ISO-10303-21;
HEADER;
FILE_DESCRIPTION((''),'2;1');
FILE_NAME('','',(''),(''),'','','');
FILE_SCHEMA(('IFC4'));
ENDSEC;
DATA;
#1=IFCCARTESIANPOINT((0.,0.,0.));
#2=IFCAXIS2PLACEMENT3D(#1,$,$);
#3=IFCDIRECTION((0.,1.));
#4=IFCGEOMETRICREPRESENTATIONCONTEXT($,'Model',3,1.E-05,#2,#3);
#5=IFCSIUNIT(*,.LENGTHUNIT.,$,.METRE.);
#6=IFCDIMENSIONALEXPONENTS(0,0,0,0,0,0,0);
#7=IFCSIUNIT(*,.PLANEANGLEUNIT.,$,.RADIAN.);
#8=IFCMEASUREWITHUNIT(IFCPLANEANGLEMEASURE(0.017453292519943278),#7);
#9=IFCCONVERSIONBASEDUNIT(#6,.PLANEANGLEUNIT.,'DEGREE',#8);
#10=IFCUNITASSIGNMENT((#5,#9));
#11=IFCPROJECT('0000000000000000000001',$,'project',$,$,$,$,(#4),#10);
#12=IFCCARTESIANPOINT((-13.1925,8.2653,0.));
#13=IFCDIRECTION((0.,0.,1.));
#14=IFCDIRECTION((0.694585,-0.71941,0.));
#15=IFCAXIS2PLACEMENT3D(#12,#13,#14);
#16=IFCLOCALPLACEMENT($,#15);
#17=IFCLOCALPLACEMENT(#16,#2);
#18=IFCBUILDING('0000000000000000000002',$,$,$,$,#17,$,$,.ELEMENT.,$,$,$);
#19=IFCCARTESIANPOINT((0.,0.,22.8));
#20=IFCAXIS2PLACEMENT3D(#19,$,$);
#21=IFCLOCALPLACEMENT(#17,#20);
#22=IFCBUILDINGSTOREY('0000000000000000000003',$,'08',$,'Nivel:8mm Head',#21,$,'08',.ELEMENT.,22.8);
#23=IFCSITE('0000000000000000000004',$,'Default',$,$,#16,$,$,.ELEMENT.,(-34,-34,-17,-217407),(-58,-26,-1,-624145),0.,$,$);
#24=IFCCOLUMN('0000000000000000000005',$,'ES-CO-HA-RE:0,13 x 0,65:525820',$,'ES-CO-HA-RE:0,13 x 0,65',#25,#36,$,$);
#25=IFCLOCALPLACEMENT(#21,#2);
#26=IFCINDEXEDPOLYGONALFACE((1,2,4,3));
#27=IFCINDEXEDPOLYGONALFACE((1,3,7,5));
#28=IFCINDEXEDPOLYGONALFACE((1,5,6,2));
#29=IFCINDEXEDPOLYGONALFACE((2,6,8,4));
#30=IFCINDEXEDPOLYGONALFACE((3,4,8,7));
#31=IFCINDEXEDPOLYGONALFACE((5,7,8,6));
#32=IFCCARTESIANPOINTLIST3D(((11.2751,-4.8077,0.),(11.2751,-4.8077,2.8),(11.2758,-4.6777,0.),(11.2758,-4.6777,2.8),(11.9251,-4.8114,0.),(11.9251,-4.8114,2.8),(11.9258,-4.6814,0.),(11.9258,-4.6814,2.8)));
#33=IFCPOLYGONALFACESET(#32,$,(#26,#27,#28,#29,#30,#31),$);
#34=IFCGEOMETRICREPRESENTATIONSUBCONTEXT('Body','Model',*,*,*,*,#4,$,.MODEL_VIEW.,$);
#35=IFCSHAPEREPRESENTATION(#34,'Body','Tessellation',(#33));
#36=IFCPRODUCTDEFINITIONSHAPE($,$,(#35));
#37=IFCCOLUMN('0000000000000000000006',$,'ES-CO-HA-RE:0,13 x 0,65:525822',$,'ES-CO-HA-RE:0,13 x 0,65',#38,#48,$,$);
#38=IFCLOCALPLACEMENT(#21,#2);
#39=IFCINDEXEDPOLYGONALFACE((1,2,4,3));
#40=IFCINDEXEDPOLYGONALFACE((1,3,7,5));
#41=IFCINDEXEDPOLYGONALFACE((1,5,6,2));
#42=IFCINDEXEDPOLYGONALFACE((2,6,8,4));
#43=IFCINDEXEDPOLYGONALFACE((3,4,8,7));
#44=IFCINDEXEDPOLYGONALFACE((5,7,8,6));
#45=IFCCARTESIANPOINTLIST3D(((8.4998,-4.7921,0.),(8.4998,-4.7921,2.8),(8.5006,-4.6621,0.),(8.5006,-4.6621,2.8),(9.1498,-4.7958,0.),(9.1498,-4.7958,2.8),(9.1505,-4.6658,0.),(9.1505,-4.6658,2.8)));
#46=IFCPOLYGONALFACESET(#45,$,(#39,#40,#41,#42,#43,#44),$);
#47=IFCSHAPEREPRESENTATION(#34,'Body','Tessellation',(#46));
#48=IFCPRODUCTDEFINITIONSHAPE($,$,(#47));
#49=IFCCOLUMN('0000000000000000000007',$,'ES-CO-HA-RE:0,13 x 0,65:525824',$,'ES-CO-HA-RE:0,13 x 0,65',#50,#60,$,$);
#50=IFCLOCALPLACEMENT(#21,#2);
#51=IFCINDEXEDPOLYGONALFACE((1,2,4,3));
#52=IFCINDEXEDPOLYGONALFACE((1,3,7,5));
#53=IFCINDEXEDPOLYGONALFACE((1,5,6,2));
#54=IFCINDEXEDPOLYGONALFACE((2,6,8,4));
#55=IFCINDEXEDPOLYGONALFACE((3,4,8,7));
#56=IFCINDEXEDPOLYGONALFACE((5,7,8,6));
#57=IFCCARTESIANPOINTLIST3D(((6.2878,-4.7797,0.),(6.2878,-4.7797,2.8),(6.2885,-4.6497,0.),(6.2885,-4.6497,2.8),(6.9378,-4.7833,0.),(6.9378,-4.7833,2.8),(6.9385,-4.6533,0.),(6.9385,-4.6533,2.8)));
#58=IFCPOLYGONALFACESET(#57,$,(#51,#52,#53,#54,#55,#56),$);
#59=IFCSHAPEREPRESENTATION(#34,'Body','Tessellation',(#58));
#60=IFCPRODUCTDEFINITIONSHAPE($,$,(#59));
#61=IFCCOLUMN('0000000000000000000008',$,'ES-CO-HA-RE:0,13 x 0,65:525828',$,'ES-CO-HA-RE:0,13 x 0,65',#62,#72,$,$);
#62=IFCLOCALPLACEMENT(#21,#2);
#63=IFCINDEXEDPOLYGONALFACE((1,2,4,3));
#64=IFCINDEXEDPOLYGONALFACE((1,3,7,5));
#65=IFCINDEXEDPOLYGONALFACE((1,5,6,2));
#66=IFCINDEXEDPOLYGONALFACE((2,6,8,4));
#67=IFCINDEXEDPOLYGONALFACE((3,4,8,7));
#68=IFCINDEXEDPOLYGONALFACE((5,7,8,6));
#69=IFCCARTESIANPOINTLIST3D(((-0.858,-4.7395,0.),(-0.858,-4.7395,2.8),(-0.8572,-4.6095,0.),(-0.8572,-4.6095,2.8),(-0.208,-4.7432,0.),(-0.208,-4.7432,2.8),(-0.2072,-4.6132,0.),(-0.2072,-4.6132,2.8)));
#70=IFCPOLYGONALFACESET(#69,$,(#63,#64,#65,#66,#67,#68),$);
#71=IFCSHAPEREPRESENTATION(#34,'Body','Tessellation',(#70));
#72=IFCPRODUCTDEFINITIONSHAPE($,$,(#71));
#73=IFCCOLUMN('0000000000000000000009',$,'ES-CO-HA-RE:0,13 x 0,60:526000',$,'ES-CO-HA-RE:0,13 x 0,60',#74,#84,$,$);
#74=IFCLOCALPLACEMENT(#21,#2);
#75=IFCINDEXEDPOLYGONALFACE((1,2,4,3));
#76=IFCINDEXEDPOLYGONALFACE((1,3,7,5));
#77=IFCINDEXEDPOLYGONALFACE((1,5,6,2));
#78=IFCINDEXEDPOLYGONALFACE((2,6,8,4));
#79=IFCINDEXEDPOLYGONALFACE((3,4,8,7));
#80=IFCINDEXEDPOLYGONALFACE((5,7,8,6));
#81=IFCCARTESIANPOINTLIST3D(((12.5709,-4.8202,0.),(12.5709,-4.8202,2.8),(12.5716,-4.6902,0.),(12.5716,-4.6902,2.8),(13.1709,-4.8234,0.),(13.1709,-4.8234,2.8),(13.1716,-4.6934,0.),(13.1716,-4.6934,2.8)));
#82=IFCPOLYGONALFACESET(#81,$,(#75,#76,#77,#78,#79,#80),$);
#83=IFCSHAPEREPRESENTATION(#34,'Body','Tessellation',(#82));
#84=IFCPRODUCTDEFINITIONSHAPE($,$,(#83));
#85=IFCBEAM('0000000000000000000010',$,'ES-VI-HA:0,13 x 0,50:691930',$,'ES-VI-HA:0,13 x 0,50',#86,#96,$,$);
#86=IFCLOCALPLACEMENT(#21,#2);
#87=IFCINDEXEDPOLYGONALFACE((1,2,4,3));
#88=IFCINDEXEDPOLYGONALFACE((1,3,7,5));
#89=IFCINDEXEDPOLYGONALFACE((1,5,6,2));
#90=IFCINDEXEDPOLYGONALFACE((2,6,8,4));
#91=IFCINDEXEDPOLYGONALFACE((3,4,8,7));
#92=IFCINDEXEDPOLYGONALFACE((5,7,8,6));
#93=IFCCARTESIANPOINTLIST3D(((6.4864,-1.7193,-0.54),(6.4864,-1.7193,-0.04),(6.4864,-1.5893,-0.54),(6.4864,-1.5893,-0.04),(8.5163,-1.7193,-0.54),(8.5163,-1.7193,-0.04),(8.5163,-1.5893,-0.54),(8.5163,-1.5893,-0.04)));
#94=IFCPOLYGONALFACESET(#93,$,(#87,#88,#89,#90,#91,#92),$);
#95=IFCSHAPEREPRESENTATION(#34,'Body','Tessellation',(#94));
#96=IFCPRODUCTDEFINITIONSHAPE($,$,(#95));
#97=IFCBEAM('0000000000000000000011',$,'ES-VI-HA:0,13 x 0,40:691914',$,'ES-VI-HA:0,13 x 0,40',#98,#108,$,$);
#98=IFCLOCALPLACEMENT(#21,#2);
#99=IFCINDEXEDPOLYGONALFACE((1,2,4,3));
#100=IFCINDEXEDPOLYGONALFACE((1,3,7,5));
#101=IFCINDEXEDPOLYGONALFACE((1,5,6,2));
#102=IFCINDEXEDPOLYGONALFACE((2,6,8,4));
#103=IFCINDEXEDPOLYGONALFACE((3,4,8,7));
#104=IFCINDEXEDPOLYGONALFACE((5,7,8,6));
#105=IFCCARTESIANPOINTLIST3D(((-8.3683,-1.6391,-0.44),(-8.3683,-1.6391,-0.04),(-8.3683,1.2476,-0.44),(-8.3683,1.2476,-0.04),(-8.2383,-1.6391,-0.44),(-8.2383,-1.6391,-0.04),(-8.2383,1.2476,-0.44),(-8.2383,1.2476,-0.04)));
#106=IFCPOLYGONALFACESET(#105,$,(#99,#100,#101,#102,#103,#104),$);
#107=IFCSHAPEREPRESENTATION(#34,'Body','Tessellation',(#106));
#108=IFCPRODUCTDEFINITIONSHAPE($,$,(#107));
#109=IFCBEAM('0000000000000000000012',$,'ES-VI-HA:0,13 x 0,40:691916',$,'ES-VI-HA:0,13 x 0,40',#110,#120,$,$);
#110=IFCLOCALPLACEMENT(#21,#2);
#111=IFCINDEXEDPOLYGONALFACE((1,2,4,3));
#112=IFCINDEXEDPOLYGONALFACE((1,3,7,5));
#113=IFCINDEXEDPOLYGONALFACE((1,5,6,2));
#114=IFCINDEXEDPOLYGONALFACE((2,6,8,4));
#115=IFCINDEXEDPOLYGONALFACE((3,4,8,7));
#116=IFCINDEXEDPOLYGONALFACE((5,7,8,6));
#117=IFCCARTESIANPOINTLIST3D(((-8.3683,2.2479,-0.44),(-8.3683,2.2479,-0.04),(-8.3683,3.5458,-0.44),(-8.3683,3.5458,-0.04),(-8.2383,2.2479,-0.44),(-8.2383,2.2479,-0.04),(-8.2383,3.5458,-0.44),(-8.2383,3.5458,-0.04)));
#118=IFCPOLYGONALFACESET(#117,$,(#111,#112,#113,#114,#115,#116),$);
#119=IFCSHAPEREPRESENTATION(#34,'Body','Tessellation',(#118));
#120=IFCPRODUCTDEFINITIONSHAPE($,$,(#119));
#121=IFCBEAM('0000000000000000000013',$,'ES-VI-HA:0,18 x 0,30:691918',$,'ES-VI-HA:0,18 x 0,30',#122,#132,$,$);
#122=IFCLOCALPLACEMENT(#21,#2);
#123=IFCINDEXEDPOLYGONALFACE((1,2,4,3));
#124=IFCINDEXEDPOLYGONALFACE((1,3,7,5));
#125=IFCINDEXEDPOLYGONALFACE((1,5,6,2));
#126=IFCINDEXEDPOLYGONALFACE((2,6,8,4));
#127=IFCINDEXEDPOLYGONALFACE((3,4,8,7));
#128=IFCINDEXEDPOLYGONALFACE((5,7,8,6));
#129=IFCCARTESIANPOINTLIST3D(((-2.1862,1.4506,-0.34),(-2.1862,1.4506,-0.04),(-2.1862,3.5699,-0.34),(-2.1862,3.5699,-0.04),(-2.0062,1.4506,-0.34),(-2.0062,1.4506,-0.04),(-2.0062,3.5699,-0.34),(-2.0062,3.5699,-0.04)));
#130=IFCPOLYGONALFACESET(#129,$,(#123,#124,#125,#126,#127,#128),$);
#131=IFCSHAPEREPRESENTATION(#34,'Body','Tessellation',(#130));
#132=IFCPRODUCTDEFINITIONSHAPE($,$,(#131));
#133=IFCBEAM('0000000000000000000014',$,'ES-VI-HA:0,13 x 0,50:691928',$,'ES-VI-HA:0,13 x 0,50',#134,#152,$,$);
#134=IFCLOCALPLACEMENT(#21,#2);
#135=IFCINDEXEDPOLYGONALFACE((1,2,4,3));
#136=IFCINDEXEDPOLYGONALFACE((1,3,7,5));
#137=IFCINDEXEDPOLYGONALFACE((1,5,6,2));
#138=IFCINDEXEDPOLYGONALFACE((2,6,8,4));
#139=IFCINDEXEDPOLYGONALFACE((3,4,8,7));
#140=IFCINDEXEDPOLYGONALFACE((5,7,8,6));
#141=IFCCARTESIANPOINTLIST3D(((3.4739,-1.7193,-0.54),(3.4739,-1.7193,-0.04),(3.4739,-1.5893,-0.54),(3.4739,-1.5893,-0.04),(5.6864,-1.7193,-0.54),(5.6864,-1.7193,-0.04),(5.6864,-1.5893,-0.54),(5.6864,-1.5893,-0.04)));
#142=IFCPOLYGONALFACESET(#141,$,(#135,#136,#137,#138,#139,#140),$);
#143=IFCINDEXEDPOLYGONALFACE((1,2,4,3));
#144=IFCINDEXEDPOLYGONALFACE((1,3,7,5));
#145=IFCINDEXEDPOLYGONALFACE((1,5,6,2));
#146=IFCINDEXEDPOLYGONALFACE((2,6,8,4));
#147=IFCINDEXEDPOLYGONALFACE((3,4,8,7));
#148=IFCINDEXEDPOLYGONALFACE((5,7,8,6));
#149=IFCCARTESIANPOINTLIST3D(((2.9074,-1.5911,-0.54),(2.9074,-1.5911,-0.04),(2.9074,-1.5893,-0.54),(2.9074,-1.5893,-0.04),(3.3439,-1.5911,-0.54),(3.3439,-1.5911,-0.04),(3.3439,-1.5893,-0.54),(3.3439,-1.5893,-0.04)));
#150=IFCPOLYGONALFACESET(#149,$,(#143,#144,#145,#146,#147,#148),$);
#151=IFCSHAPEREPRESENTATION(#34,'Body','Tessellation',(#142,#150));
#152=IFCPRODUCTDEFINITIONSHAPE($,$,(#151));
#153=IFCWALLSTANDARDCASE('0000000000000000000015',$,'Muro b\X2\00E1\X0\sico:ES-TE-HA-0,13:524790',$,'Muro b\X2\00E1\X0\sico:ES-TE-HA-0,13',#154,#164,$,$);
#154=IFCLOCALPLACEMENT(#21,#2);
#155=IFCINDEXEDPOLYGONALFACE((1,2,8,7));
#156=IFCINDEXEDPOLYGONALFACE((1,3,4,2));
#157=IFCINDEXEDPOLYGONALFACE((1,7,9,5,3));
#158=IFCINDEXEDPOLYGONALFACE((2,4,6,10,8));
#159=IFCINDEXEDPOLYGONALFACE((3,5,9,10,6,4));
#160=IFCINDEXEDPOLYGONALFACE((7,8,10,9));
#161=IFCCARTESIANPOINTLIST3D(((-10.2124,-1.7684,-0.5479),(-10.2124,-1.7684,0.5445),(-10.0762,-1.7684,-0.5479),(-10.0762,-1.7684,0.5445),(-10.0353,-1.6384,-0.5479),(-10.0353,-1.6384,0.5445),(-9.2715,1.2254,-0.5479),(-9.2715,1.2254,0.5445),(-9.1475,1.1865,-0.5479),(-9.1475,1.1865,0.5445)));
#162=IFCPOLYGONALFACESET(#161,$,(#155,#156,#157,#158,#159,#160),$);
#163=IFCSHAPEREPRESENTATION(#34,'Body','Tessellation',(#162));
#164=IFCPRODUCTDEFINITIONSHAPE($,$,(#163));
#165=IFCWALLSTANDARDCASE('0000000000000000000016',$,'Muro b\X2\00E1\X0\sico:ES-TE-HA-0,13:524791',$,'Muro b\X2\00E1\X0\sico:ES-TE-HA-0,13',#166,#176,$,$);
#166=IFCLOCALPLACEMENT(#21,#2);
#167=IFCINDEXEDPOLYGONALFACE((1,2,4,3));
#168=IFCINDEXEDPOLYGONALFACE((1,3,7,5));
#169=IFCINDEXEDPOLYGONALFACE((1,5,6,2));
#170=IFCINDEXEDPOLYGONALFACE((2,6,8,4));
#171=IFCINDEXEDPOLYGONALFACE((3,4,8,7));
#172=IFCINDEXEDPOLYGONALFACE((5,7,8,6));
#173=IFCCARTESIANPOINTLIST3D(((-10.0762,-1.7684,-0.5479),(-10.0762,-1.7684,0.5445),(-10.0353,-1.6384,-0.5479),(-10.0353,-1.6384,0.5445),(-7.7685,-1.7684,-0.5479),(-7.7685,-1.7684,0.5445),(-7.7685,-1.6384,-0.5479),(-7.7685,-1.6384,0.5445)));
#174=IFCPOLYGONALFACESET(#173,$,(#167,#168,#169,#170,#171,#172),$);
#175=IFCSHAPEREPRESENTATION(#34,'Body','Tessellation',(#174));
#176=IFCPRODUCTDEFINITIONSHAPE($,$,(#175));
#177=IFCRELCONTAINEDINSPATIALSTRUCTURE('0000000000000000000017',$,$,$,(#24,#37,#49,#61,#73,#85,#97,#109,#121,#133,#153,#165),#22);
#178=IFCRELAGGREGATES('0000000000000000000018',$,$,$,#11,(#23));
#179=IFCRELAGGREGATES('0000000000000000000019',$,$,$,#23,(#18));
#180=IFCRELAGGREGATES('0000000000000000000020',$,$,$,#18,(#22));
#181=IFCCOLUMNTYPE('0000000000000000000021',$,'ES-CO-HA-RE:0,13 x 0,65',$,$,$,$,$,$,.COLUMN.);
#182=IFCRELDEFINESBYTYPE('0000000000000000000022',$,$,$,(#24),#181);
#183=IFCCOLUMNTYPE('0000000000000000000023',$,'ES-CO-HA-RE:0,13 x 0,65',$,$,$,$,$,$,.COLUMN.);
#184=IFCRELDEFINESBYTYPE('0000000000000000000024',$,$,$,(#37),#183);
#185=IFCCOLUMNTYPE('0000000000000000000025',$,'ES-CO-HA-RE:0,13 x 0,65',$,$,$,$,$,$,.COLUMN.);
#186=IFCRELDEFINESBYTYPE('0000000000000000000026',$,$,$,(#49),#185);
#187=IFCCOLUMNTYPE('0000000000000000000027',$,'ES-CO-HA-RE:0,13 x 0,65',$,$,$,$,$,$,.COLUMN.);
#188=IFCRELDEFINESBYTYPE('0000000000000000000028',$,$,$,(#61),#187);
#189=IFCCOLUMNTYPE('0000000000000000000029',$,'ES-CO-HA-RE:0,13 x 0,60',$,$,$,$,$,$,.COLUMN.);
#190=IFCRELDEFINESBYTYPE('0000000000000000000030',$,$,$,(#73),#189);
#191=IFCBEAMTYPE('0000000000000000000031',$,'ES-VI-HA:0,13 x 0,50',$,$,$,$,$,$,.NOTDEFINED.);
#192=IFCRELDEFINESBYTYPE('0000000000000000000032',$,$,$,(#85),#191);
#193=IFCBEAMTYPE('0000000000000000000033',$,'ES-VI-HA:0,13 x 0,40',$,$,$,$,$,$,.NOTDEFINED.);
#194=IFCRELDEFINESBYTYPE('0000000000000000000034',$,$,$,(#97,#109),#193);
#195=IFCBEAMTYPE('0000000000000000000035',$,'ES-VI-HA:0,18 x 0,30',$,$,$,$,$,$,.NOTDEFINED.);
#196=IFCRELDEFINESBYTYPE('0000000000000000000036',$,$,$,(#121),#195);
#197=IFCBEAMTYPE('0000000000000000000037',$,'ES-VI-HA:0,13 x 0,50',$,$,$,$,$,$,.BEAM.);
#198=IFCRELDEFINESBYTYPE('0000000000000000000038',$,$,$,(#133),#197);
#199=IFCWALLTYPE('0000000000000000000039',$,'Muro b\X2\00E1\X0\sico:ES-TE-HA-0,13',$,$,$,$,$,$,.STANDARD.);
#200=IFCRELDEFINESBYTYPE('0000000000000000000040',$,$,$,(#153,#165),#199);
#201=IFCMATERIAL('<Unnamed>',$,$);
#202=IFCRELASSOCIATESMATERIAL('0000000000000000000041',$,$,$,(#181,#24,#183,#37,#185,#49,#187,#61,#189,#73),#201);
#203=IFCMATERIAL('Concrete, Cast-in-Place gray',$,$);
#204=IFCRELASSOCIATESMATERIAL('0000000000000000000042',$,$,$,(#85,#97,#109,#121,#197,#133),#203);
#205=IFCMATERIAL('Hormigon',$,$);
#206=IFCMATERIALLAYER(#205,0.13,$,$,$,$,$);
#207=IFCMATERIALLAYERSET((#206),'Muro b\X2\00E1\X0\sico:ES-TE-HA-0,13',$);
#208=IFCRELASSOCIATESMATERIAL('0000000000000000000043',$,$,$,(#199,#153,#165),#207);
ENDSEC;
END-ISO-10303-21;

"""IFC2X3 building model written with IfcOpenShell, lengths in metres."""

from ifc_helpers import new_model, entity, si_unit, converted_unit, direction, frame, frame_2d, origin, origin_2d_with_axis, place, context, subcontext, project, spatial, polyline, rectangle, outline, extrude, source, transform, mapped, material, layer, layer_set, layer_usage, type_object, type_shapes, element, save


model = new_model("IFC2X3")

# Units and contexts
model_context = context("Model", 3, precision=1e-05, world=origin(), true_north=direction((0.0, 1.0)))
body_context = subcontext(model_context, "Body", "Model", "MODEL_VIEW")
ifc_project = project(units=[si_unit("LENGTHUNIT", "METRE"), converted_unit("PLANEANGLEUNIT", "DEGREE", entity("IfcPlaneAngleMeasure", 0.017453292519943278), si_unit("PLANEANGLEUNIT", "RADIAN"), dimensions=[0, 0, 0, 0, 0, 0, 0])], contexts=[model_context])

# Site, building, storey
site_placement = place(None, frame((-13.1925, 8.2653, 0.0), z_axis=(0.0, 0.0, 1.0), x_axis=(0.694585, -0.71941, 0.0)))
site = spatial("IfcSite", under=ifc_project, at=site_placement, Name="Default", CompositionType="ELEMENT", RefLatitude=(-34, -34, -17, -217407), RefLongitude=(-58, -26, -1, -624145), RefElevation=0.0)
building_placement = place(site_placement, origin())
building = spatial("IfcBuilding", under=site, at=building_placement, CompositionType="ELEMENT")
storey_placement = place(building_placement, frame((0.0, 0.0, 22.8)))
storey = spatial("IfcBuildingStorey", under=building, at=storey_placement, Name="08", ObjectType="Nivel:8mm Head", LongName="08", CompositionType="ELEMENT", Elevation=22.8)

# Columns
ifc_material_1 = material(Name="<Unnamed>")
ifc_material_2 = material(Name="Hormigon")
column_type_1 = type_object("IfcColumnType", Name="ES-CO-HA-RE:0,13 x 0,65", PredefinedType="COLUMN", material=ifc_material_1)
shared_shape_1 = source(origin(), body_context, "Body", "SweptSolid", [
    extrude(rectangle(XDim=0.65, YDim=0.13, at=frame_2d((0.0, 0.0), x_axis=(1.0, 0.0))), frame((11.6005, -4.7445, 22.8), z_axis=(0.0, 0.0, 1.0), x_axis=(-0.999984, 0.005619, 0.0)), (0.0, 0.0, 1.0), 2.8),
])
type_shapes(column_type_1, [shared_shape_1])
column_1_placement = place(storey_placement, frame((0.0, 0.0, -22.8)))
element("IfcColumn", 1, at=column_1_placement, inside=storey, type_object=column_type_1, material=ifc_material_1, Name="ES-CO-HA-RE:0,13 x 0,65:525820", ObjectType="ES-CO-HA-RE:0,13 x 0,65", context=body_context, shape_type="MappedRepresentation", body=[
    mapped(shared_shape_1, transform((0.0, 0.0, 0.0), scale=1.0)),
])
column_type_2 = type_object("IfcColumnType", Name="ES-CO-HA-RE:0,13 x 0,65", PredefinedType="COLUMN", material=ifc_material_1)
shared_shape_2 = source(origin(), body_context, "Body", "SweptSolid", [
    extrude(rectangle(XDim=0.65, YDim=0.13, at=origin_2d_with_axis()), frame((8.8252, -4.7289, 22.8), z_axis=(0.0, 0.0, 1.0), x_axis=(-0.999984, 0.005619, 0.0)), (0.0, 0.0, 1.0), 2.8),
])
type_shapes(column_type_2, [shared_shape_2])
column_2_placement = place(storey_placement, frame((0.0, 0.0, -22.8)))
element("IfcColumn", 2, at=column_2_placement, inside=storey, type_object=column_type_2, material=ifc_material_1, Name="ES-CO-HA-RE:0,13 x 0,65:525822", ObjectType="ES-CO-HA-RE:0,13 x 0,65", context=body_context, shape_type="MappedRepresentation", body=[
    mapped(shared_shape_2, transform((0.0, 0.0, 0.0), scale=1.0)),
])
column_type_3 = type_object("IfcColumnType", Name="ES-CO-HA-RE:0,13 x 0,65", PredefinedType="COLUMN", material=ifc_material_1)
shared_shape_3 = source(origin(), body_context, "Body", "SweptSolid", [
    extrude(rectangle(XDim=0.65, YDim=0.13, at=frame_2d((0.0, 0.0), x_axis=(1.0, 0.0))), frame((6.6131, -4.7165, 22.8), z_axis=(0.0, 0.0, 1.0), x_axis=(-0.999984, 0.005619, 0.0)), (0.0, 0.0, 1.0), 2.8),
])
type_shapes(column_type_3, [shared_shape_3])
column_3_placement = place(storey_placement, frame((0.0, 0.0, -22.8)))
element("IfcColumn", 3, at=column_3_placement, inside=storey, type_object=column_type_3, material=ifc_material_1, Name="ES-CO-HA-RE:0,13 x 0,65:525824", ObjectType="ES-CO-HA-RE:0,13 x 0,65", context=body_context, shape_type="MappedRepresentation", body=[
    mapped(shared_shape_3, transform((0.0, 0.0, 0.0), scale=1.0)),
])
column_type_4 = type_object("IfcColumnType", Name="ES-CO-HA-RE:0,13 x 0,65", PredefinedType="COLUMN", material=ifc_material_1)
shared_shape_4 = source(origin(), body_context, "Body", "SweptSolid", [
    extrude(rectangle(XDim=0.65, YDim=0.13, at=frame_2d((0.0, 0.0), x_axis=(1.0, 0.0))), frame((-0.5326, -4.6764, 22.8), z_axis=(0.0, 0.0, 1.0), x_axis=(-0.999984, 0.005619, 0.0)), (0.0, 0.0, 1.0), 2.8),
])
type_shapes(column_type_4, [shared_shape_4])
column_4_placement = place(storey_placement, frame((0.0, 0.0, -22.8)))
element("IfcColumn", 4, at=column_4_placement, inside=storey, type_object=column_type_4, material=ifc_material_1, Name="ES-CO-HA-RE:0,13 x 0,65:525828", ObjectType="ES-CO-HA-RE:0,13 x 0,65", context=body_context, shape_type="MappedRepresentation", body=[
    mapped(shared_shape_4, transform((0.0, 0.0, 0.0), scale=1.0)),
])
column_type_5 = type_object("IfcColumnType", Name="ES-CO-HA-RE:0,13 x 0,60", PredefinedType="COLUMN", material=ifc_material_1)
shared_shape_5 = source(origin(), body_context, "Body", "SweptSolid", [
    extrude(rectangle(XDim=0.6, YDim=0.13, at=frame_2d((0.0, 0.0), x_axis=(1.0, 0.0))), frame((12.8713, -4.7568, 22.8), z_axis=(0.0, 0.0, 1.0), x_axis=(-0.999985, 0.005426, 0.0)), (0.0, 0.0, 1.0), 2.8),
])
type_shapes(column_type_5, [shared_shape_5])
column_5_placement = place(storey_placement, frame((0.0, 0.0, -22.8)))
element("IfcColumn", 5, at=column_5_placement, inside=storey, type_object=column_type_5, material=ifc_material_1, Name="ES-CO-HA-RE:0,13 x 0,60:526000", ObjectType="ES-CO-HA-RE:0,13 x 0,60", context=body_context, shape_type="MappedRepresentation", body=[
    mapped(shared_shape_5, transform((0.0, 0.0, 0.0), scale=1.0)),
])

# Beams
ifc_material_3 = material(Name="Concrete, Cast-in-Place gray")
beam_type_1 = type_object("IfcBeamType", Name="ES-VI-HA:0,13 x 0,50", PredefinedType="NOTDEFINED")
beam_1_placement = place(storey_placement, frame((5.7373, -1.6543, -0.04)))
element("IfcBeam", 6, at=beam_1_placement, inside=storey, type_object=beam_type_1, material=ifc_material_3, Name="ES-VI-HA:0,13 x 0,50:691930", ObjectType="ES-VI-HA:0,13 x 0,50", context=body_context, shape_type="SweptSolid", body=[
    extrude(rectangle(XDim=0.5, YDim=0.13, at=frame_2d((0.0, 0.0), x_axis=(1.0, 0.0))), frame((0.7491, 0.0, -0.25), z_axis=(1.0, 0.0, 0.0), x_axis=(0.0, 0.0, -1.0)), (0.0, 0.0, 1.0), 2.0299),
])
beam_type_2 = type_object("IfcBeamType", Name="ES-VI-HA:0,13 x 0,40", PredefinedType="NOTDEFINED")
beam_2_placement = place(storey_placement, frame((-8.3033, -1.6391, -0.04), z_axis=(0.0, 0.0, 1.0), x_axis=(0.0, 1.0, 0.0)))
element("IfcBeam", 7, at=beam_2_placement, inside=storey, type_object=beam_type_2, material=ifc_material_3, Name="ES-VI-HA:0,13 x 0,40:691914", ObjectType="ES-VI-HA:0,13 x 0,40", context=body_context, shape_type="SweptSolid", body=[
    extrude(rectangle(XDim=0.4, YDim=0.13, at=frame_2d((0.0, 0.0), x_axis=(1.0, 0.0))), frame((0.0, 0.0, -0.2), z_axis=(1.0, 0.0, 0.0), x_axis=(0.0, 0.0, -1.0)), (0.0, 0.0, 1.0), 2.8867),
])
beam_3_placement = place(storey_placement, frame((-8.3033, 2.2479, -0.04), z_axis=(0.0, 0.0, 1.0), x_axis=(0.0, 1.0, 0.0)))
element("IfcBeam", 8, at=beam_3_placement, inside=storey, type_object=beam_type_2, material=ifc_material_3, Name="ES-VI-HA:0,13 x 0,40:691916", ObjectType="ES-VI-HA:0,13 x 0,40", context=body_context, shape_type="SweptSolid", body=[
    extrude(rectangle(XDim=0.4, YDim=0.13, at=frame_2d((0.0, 0.0), x_axis=(1.0, 0.0))), frame((0.0, 0.0, -0.2), z_axis=(1.0, 0.0, 0.0), x_axis=(0.0, 0.0, -1.0)), (0.0, 0.0, 1.0), 1.298),
])
beam_type_3 = type_object("IfcBeamType", Name="ES-VI-HA:0,18 x 0,30", PredefinedType="NOTDEFINED")
beam_4_placement = place(storey_placement, frame((-2.0962, 3.5699, -0.04), z_axis=(0.0, 0.0, 1.0), x_axis=(0.0, -1.0, 0.0)))
element("IfcBeam", 9, at=beam_4_placement, inside=storey, type_object=beam_type_3, material=ifc_material_3, Name="ES-VI-HA:0,18 x 0,30:691918", ObjectType="ES-VI-HA:0,18 x 0,30", context=body_context, shape_type="SweptSolid", body=[
    extrude(rectangle(XDim=0.3, YDim=0.18, at=origin_2d_with_axis()), frame((0.0, 0.0, -0.15), z_axis=(1.0, 0.0, 0.0), x_axis=(0.0, 0.0, -1.0)), (0.0, 0.0, 1.0), 2.1193),
])
beam_type_4 = type_object("IfcBeamType", Name="ES-VI-HA:0,13 x 0,50", PredefinedType="BEAM", material=ifc_material_3)
shared_shape_6 = source(origin(), body_context, "Body", "SweptSolid", [
    extrude(rectangle(XDim=0.5, YDim=0.13, at=frame_2d((0.0, 0.0), x_axis=(1.0, 0.0))), frame((3.4739, -1.6543, 22.51), z_axis=(1.0, 0.0, 0.0), x_axis=(0.0, 0.0, -1.0)), (0.0, 0.0, 1.0), 2.2125),
    extrude(rectangle(XDim=0.5, YDim=0.0018, at=frame_2d((0.0, 0.0), x_axis=(1.0, 0.0))), frame((2.9074, -1.5902, 22.51), z_axis=(1.0, 0.0, 0.0), x_axis=(0.0, 0.0, -1.0)), (0.0, 0.0, 1.0), 0.4365),
])
type_shapes(beam_type_4, [shared_shape_6])
beam_5_placement = place(storey_placement, frame((0.0, 0.0, -22.8)))
element("IfcBeam", 10, at=beam_5_placement, inside=storey, type_object=beam_type_4, material=ifc_material_3, Name="ES-VI-HA:0,13 x 0,50:691928", ObjectType="ES-VI-HA:0,13 x 0,50", context=body_context, shape_type="MappedRepresentation", body=[
    mapped(shared_shape_6, transform((0.0, 0.0, 0.0), scale=1.0)),
])

# Walls
ifc_layer_1 = layer(ifc_material_2, 0.13)
ifc_layer_set_1 = layer_set([ifc_layer_1], Name="Muro básico:ES-TE-HA-0,13")
ifc_layer_usage_1 = layer_usage(ifc_layer_set_1, "AXIS2", "NEGATIVE", 0.065)
wall_type = type_object("IfcWallType", Name="Muro básico:ES-TE-HA-0,13", PredefinedType="STANDARD", material=ifc_layer_set_1)
wall_1_placement = place(storey_placement, frame((-10.1504, -1.7879, -0.5479), z_axis=(0.0, 0.0, 1.0), x_axis=(0.299835, 0.953991, 0.0)))
element("IfcWallStandardCase", 11, at=wall_1_placement, inside=storey, type_object=wall_type, material=ifc_layer_usage_1, Name="Muro básico:ES-TE-HA-0,13:524790", ObjectType="Muro básico:ES-TE-HA-0,13", context=body_context, shape_type="SweptSolid", body=[
    extrude(outline(polyline([(3.1382, -0.065), (3.1382, 0.065), (0.0, 0.065), (0.0409, -0.065), (0.1771, -0.065), (3.1382, -0.065)])), origin(), (0.0, 0.0, 1.0), 1.0924),
])
ifc_layer_usage_2 = layer_usage(ifc_layer_set_1, "AXIS2", "POSITIVE", -0.065)
wall_2_placement = place(storey_placement, frame((-10.0762, -1.7034, -0.5479)))
element("IfcWallStandardCase", 12, at=wall_2_placement, inside=storey, type_object=wall_type, material=ifc_layer_usage_2, Name="Muro básico:ES-TE-HA-0,13:524791", ObjectType="Muro básico:ES-TE-HA-0,13", context=body_context, shape_type="SweptSolid", body=[
    extrude(outline(polyline([(2.3077, -0.065), (2.3077, 0.065), (0.0409, 0.065), (0.0, -0.065), (2.3077, -0.065)])), origin(), (0.0, 0.0, 1.0), 1.0924),
])

save(model, "model.ifc")
